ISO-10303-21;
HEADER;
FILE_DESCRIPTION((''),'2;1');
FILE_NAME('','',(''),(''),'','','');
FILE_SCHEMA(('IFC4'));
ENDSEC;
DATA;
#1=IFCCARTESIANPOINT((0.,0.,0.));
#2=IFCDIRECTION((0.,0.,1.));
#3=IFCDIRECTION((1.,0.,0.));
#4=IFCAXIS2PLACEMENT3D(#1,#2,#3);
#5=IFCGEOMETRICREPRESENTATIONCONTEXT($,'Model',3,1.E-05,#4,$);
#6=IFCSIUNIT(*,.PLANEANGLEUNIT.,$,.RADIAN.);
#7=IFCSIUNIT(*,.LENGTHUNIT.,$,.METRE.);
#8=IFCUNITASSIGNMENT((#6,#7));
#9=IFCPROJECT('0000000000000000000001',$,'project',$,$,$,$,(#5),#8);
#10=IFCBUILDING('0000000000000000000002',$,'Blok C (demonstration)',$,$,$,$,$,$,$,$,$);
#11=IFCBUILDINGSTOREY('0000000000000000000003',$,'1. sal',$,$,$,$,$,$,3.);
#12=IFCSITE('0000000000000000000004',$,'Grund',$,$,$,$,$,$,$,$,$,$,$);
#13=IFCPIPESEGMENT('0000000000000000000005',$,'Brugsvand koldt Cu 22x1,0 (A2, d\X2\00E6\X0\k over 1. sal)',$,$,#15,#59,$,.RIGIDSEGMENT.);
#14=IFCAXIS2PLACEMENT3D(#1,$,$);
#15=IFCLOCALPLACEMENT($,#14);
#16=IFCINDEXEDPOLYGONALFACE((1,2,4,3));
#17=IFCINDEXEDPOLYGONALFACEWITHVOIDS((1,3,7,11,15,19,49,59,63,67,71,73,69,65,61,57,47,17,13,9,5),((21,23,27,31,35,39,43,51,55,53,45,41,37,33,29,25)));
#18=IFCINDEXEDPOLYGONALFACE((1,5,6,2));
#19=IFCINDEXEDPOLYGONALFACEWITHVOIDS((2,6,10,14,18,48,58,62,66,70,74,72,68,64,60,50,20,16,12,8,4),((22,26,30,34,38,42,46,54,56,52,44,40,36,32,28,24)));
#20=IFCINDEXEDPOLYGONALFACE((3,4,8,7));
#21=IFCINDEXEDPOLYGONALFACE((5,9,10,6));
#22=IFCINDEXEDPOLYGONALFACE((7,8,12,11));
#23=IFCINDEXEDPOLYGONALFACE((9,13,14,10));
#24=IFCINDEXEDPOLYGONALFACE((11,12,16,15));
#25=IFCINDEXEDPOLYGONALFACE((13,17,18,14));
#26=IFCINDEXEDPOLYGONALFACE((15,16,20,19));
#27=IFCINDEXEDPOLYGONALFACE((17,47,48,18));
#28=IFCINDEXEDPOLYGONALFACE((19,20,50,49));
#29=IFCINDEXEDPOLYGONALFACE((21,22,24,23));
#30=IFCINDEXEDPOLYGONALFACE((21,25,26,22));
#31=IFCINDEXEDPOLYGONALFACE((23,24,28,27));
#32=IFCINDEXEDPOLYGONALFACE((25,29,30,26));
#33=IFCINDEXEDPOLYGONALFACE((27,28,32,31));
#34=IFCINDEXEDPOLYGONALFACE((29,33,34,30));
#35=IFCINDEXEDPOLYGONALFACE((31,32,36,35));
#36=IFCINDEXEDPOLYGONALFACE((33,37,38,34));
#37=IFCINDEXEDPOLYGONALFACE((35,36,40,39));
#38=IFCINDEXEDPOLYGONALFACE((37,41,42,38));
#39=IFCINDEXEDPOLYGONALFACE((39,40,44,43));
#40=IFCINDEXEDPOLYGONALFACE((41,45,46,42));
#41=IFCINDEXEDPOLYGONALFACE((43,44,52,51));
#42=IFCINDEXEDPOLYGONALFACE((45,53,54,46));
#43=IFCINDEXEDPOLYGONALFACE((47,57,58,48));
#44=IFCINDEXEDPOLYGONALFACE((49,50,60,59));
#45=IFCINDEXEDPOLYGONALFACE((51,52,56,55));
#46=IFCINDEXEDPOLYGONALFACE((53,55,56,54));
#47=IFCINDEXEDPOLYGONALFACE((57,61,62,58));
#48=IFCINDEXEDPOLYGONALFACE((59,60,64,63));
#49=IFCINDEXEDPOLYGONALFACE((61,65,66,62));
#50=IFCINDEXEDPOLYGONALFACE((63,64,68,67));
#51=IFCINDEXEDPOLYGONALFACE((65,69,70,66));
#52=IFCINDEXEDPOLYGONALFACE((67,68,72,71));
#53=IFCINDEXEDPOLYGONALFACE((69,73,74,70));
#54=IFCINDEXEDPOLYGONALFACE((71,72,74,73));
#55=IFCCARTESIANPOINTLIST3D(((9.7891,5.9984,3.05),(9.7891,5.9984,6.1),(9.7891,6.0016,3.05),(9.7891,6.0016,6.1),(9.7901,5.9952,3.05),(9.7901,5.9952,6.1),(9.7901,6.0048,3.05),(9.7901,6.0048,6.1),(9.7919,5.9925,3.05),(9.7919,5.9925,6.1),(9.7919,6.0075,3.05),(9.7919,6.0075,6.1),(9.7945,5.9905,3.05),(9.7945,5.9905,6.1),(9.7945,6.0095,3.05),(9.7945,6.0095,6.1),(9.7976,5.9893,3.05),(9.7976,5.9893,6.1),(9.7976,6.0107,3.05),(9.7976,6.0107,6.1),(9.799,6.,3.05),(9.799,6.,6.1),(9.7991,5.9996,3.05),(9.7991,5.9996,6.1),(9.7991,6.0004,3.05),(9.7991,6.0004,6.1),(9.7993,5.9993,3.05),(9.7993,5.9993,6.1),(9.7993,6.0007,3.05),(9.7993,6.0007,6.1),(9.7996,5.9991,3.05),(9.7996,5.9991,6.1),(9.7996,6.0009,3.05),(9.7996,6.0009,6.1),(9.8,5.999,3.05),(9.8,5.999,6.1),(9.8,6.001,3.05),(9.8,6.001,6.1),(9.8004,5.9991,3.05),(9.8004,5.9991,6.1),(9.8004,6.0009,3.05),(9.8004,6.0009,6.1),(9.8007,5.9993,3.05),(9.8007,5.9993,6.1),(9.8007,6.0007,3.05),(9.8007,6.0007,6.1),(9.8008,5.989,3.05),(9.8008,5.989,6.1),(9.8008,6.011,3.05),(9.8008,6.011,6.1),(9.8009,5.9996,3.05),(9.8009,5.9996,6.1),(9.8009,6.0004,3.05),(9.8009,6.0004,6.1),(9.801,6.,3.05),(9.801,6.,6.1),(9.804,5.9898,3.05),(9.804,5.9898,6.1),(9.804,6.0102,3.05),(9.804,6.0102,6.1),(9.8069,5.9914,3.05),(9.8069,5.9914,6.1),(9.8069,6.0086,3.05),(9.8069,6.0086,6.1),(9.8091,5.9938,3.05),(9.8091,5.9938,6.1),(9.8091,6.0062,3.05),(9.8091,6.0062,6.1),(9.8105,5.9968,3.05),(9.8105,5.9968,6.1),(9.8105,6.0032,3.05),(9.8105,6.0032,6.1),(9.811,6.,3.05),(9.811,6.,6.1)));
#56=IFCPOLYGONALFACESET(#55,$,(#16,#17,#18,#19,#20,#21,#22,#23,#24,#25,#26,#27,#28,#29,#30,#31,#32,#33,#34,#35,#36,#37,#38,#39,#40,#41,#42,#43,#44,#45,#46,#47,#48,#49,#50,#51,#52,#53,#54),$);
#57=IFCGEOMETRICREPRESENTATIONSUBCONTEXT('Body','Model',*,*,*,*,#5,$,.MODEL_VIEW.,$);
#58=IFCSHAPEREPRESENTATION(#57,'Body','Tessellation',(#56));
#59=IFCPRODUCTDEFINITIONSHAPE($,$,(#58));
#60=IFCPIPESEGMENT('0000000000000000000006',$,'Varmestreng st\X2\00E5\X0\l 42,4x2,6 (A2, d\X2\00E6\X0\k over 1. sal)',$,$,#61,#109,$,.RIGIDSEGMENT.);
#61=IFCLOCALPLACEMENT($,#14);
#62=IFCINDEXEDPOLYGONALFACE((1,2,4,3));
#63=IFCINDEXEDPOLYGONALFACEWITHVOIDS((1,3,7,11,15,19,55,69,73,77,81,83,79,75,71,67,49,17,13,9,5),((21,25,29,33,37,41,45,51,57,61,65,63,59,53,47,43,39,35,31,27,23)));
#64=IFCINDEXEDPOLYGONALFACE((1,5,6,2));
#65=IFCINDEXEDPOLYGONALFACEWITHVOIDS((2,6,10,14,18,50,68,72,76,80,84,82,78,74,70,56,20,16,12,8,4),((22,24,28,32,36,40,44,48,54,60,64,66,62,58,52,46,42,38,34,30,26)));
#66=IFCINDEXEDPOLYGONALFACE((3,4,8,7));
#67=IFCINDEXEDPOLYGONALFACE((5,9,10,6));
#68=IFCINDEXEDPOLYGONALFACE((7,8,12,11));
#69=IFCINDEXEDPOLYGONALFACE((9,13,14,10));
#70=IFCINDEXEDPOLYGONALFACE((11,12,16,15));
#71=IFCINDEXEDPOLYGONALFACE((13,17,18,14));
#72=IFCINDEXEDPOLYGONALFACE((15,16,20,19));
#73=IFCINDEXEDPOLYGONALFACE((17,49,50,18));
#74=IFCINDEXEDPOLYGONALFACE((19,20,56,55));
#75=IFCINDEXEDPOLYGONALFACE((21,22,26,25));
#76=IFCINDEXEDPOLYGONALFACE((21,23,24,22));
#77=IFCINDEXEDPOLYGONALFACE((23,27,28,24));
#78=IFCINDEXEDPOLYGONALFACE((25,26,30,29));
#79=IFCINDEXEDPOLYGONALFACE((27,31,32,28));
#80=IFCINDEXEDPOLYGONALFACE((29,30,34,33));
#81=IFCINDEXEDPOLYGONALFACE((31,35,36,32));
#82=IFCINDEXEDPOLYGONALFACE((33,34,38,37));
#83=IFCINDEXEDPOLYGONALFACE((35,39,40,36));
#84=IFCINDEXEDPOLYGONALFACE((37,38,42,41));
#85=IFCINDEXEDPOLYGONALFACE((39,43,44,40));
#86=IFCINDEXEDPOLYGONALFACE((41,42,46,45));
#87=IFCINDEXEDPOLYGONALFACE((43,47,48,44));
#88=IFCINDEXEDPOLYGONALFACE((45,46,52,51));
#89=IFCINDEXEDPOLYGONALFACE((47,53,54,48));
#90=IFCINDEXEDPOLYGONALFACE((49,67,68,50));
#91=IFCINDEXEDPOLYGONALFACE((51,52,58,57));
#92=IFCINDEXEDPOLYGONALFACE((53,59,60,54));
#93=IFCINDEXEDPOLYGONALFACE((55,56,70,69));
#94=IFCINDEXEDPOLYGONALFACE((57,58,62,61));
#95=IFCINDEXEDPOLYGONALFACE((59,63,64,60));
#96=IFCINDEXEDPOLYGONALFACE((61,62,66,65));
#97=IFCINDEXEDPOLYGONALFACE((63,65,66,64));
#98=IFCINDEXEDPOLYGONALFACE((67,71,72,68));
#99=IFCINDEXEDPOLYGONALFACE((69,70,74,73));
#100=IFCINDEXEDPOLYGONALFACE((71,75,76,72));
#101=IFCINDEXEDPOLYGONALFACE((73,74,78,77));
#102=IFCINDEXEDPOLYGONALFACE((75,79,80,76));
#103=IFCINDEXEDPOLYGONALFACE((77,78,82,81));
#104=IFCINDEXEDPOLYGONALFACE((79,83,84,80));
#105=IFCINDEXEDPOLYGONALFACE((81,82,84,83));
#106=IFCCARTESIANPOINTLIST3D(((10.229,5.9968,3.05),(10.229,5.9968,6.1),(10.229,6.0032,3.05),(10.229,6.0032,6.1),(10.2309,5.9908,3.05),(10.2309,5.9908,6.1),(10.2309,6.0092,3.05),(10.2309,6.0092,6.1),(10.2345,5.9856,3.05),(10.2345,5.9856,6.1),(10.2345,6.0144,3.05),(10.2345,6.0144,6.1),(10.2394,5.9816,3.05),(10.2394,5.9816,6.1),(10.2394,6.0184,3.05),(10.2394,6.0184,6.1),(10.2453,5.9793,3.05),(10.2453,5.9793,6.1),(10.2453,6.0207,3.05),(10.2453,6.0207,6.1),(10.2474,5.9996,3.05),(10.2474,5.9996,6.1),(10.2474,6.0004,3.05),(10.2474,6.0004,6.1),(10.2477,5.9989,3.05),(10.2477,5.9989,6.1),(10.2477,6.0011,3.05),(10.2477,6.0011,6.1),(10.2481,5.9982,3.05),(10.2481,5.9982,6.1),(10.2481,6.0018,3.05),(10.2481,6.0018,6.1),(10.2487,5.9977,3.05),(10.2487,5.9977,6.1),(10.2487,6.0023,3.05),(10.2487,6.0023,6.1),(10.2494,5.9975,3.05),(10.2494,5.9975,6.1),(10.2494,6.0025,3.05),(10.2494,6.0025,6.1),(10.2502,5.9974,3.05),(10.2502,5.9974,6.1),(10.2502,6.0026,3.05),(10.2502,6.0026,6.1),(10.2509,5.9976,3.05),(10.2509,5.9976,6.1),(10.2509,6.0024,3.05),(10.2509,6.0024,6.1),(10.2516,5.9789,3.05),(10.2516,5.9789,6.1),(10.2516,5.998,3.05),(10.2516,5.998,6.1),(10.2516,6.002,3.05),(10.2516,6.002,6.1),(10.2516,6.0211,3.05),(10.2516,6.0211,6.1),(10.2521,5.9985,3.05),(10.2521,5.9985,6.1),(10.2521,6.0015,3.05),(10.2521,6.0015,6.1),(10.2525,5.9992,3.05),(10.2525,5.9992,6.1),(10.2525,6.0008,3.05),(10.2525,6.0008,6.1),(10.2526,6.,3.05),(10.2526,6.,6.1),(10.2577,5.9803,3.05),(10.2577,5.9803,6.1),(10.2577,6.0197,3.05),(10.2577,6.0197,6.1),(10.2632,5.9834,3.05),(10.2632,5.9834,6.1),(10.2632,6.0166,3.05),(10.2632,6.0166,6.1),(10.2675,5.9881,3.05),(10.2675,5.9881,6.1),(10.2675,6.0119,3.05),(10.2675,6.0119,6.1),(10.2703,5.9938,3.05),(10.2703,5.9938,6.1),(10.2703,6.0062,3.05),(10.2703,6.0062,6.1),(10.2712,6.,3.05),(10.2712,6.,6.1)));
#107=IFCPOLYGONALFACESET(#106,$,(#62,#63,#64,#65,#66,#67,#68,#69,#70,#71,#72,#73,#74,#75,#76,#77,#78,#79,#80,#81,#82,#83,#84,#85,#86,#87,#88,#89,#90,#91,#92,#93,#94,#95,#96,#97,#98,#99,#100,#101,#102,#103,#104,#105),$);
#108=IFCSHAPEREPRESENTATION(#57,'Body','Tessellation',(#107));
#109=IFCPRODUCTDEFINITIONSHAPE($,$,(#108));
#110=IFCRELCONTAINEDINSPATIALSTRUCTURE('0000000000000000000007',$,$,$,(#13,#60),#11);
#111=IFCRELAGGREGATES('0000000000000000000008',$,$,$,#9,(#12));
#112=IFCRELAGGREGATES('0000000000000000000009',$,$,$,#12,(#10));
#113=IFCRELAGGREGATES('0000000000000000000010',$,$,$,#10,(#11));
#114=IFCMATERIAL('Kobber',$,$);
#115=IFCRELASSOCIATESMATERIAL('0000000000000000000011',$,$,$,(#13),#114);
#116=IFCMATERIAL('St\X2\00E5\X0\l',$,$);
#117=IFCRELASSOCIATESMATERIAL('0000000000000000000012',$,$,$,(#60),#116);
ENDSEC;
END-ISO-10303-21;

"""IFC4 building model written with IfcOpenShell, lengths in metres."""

from ifc_helpers import new_model, si_unit, frame, origin_with_axes, place, context, subcontext, project, spatial, hollow_circle, extrude, material, element, save


model = new_model("IFC4")

# Units and contexts
model_context = context("Model", 3, precision=1e-05, world=origin_with_axes())
body_context = subcontext(model_context, "Body", "Model", "MODEL_VIEW")
ifc_project = project(units=[si_unit("PLANEANGLEUNIT", "RADIAN"), si_unit("LENGTHUNIT", "METRE")], contexts=[model_context])

# Site, building, storey
site = spatial("IfcSite", under=ifc_project, Name="Grund")
building = spatial("IfcBuilding", under=site, Name="Blok C (demonstration)")
storey = spatial("IfcBuildingStorey", under=building, Name="1. sal", Elevation=3.0)

# Pipe segments
ifc_material_1 = material(Name="Kobber")
ifc_material_2 = material(Name="Stål")
pipe_segment_1_placement = place(None, origin_with_axes())
element("IfcPipeSegment", 1, at=pipe_segment_1_placement, inside=storey, material=ifc_material_1, Name="Brugsvand koldt Cu 22x1,0 (A2, dæk over 1. sal)", PredefinedType="RIGIDSEGMENT", context=body_context, shape_type="SweptSolid", body=[
    extrude(hollow_circle(Radius=0.011, WallThickness=0.01), frame((9.8, 6.0, 3.05), z_axis=(0.0, 0.0, 1.0), x_axis=(1.0, 0.0, 0.0)), (0.0, 0.0, 1.0), 3.05),
])
pipe_segment_2_placement = place(None, origin_with_axes())
element("IfcPipeSegment", 2, at=pipe_segment_2_placement, inside=storey, material=ifc_material_2, Name="Varmestreng stål 42,4x2,6 (A2, dæk over 1. sal)", PredefinedType="RIGIDSEGMENT", context=body_context, shape_type="SweptSolid", body=[
    extrude(hollow_circle(Radius=0.0212, WallThickness=0.0186), frame((10.25, 6.0, 3.05), z_axis=(0.0, 0.0, 1.0), x_axis=(1.0, 0.0, 0.0)), (0.0, 0.0, 1.0), 3.05),
])

save(model, "model.ifc")
